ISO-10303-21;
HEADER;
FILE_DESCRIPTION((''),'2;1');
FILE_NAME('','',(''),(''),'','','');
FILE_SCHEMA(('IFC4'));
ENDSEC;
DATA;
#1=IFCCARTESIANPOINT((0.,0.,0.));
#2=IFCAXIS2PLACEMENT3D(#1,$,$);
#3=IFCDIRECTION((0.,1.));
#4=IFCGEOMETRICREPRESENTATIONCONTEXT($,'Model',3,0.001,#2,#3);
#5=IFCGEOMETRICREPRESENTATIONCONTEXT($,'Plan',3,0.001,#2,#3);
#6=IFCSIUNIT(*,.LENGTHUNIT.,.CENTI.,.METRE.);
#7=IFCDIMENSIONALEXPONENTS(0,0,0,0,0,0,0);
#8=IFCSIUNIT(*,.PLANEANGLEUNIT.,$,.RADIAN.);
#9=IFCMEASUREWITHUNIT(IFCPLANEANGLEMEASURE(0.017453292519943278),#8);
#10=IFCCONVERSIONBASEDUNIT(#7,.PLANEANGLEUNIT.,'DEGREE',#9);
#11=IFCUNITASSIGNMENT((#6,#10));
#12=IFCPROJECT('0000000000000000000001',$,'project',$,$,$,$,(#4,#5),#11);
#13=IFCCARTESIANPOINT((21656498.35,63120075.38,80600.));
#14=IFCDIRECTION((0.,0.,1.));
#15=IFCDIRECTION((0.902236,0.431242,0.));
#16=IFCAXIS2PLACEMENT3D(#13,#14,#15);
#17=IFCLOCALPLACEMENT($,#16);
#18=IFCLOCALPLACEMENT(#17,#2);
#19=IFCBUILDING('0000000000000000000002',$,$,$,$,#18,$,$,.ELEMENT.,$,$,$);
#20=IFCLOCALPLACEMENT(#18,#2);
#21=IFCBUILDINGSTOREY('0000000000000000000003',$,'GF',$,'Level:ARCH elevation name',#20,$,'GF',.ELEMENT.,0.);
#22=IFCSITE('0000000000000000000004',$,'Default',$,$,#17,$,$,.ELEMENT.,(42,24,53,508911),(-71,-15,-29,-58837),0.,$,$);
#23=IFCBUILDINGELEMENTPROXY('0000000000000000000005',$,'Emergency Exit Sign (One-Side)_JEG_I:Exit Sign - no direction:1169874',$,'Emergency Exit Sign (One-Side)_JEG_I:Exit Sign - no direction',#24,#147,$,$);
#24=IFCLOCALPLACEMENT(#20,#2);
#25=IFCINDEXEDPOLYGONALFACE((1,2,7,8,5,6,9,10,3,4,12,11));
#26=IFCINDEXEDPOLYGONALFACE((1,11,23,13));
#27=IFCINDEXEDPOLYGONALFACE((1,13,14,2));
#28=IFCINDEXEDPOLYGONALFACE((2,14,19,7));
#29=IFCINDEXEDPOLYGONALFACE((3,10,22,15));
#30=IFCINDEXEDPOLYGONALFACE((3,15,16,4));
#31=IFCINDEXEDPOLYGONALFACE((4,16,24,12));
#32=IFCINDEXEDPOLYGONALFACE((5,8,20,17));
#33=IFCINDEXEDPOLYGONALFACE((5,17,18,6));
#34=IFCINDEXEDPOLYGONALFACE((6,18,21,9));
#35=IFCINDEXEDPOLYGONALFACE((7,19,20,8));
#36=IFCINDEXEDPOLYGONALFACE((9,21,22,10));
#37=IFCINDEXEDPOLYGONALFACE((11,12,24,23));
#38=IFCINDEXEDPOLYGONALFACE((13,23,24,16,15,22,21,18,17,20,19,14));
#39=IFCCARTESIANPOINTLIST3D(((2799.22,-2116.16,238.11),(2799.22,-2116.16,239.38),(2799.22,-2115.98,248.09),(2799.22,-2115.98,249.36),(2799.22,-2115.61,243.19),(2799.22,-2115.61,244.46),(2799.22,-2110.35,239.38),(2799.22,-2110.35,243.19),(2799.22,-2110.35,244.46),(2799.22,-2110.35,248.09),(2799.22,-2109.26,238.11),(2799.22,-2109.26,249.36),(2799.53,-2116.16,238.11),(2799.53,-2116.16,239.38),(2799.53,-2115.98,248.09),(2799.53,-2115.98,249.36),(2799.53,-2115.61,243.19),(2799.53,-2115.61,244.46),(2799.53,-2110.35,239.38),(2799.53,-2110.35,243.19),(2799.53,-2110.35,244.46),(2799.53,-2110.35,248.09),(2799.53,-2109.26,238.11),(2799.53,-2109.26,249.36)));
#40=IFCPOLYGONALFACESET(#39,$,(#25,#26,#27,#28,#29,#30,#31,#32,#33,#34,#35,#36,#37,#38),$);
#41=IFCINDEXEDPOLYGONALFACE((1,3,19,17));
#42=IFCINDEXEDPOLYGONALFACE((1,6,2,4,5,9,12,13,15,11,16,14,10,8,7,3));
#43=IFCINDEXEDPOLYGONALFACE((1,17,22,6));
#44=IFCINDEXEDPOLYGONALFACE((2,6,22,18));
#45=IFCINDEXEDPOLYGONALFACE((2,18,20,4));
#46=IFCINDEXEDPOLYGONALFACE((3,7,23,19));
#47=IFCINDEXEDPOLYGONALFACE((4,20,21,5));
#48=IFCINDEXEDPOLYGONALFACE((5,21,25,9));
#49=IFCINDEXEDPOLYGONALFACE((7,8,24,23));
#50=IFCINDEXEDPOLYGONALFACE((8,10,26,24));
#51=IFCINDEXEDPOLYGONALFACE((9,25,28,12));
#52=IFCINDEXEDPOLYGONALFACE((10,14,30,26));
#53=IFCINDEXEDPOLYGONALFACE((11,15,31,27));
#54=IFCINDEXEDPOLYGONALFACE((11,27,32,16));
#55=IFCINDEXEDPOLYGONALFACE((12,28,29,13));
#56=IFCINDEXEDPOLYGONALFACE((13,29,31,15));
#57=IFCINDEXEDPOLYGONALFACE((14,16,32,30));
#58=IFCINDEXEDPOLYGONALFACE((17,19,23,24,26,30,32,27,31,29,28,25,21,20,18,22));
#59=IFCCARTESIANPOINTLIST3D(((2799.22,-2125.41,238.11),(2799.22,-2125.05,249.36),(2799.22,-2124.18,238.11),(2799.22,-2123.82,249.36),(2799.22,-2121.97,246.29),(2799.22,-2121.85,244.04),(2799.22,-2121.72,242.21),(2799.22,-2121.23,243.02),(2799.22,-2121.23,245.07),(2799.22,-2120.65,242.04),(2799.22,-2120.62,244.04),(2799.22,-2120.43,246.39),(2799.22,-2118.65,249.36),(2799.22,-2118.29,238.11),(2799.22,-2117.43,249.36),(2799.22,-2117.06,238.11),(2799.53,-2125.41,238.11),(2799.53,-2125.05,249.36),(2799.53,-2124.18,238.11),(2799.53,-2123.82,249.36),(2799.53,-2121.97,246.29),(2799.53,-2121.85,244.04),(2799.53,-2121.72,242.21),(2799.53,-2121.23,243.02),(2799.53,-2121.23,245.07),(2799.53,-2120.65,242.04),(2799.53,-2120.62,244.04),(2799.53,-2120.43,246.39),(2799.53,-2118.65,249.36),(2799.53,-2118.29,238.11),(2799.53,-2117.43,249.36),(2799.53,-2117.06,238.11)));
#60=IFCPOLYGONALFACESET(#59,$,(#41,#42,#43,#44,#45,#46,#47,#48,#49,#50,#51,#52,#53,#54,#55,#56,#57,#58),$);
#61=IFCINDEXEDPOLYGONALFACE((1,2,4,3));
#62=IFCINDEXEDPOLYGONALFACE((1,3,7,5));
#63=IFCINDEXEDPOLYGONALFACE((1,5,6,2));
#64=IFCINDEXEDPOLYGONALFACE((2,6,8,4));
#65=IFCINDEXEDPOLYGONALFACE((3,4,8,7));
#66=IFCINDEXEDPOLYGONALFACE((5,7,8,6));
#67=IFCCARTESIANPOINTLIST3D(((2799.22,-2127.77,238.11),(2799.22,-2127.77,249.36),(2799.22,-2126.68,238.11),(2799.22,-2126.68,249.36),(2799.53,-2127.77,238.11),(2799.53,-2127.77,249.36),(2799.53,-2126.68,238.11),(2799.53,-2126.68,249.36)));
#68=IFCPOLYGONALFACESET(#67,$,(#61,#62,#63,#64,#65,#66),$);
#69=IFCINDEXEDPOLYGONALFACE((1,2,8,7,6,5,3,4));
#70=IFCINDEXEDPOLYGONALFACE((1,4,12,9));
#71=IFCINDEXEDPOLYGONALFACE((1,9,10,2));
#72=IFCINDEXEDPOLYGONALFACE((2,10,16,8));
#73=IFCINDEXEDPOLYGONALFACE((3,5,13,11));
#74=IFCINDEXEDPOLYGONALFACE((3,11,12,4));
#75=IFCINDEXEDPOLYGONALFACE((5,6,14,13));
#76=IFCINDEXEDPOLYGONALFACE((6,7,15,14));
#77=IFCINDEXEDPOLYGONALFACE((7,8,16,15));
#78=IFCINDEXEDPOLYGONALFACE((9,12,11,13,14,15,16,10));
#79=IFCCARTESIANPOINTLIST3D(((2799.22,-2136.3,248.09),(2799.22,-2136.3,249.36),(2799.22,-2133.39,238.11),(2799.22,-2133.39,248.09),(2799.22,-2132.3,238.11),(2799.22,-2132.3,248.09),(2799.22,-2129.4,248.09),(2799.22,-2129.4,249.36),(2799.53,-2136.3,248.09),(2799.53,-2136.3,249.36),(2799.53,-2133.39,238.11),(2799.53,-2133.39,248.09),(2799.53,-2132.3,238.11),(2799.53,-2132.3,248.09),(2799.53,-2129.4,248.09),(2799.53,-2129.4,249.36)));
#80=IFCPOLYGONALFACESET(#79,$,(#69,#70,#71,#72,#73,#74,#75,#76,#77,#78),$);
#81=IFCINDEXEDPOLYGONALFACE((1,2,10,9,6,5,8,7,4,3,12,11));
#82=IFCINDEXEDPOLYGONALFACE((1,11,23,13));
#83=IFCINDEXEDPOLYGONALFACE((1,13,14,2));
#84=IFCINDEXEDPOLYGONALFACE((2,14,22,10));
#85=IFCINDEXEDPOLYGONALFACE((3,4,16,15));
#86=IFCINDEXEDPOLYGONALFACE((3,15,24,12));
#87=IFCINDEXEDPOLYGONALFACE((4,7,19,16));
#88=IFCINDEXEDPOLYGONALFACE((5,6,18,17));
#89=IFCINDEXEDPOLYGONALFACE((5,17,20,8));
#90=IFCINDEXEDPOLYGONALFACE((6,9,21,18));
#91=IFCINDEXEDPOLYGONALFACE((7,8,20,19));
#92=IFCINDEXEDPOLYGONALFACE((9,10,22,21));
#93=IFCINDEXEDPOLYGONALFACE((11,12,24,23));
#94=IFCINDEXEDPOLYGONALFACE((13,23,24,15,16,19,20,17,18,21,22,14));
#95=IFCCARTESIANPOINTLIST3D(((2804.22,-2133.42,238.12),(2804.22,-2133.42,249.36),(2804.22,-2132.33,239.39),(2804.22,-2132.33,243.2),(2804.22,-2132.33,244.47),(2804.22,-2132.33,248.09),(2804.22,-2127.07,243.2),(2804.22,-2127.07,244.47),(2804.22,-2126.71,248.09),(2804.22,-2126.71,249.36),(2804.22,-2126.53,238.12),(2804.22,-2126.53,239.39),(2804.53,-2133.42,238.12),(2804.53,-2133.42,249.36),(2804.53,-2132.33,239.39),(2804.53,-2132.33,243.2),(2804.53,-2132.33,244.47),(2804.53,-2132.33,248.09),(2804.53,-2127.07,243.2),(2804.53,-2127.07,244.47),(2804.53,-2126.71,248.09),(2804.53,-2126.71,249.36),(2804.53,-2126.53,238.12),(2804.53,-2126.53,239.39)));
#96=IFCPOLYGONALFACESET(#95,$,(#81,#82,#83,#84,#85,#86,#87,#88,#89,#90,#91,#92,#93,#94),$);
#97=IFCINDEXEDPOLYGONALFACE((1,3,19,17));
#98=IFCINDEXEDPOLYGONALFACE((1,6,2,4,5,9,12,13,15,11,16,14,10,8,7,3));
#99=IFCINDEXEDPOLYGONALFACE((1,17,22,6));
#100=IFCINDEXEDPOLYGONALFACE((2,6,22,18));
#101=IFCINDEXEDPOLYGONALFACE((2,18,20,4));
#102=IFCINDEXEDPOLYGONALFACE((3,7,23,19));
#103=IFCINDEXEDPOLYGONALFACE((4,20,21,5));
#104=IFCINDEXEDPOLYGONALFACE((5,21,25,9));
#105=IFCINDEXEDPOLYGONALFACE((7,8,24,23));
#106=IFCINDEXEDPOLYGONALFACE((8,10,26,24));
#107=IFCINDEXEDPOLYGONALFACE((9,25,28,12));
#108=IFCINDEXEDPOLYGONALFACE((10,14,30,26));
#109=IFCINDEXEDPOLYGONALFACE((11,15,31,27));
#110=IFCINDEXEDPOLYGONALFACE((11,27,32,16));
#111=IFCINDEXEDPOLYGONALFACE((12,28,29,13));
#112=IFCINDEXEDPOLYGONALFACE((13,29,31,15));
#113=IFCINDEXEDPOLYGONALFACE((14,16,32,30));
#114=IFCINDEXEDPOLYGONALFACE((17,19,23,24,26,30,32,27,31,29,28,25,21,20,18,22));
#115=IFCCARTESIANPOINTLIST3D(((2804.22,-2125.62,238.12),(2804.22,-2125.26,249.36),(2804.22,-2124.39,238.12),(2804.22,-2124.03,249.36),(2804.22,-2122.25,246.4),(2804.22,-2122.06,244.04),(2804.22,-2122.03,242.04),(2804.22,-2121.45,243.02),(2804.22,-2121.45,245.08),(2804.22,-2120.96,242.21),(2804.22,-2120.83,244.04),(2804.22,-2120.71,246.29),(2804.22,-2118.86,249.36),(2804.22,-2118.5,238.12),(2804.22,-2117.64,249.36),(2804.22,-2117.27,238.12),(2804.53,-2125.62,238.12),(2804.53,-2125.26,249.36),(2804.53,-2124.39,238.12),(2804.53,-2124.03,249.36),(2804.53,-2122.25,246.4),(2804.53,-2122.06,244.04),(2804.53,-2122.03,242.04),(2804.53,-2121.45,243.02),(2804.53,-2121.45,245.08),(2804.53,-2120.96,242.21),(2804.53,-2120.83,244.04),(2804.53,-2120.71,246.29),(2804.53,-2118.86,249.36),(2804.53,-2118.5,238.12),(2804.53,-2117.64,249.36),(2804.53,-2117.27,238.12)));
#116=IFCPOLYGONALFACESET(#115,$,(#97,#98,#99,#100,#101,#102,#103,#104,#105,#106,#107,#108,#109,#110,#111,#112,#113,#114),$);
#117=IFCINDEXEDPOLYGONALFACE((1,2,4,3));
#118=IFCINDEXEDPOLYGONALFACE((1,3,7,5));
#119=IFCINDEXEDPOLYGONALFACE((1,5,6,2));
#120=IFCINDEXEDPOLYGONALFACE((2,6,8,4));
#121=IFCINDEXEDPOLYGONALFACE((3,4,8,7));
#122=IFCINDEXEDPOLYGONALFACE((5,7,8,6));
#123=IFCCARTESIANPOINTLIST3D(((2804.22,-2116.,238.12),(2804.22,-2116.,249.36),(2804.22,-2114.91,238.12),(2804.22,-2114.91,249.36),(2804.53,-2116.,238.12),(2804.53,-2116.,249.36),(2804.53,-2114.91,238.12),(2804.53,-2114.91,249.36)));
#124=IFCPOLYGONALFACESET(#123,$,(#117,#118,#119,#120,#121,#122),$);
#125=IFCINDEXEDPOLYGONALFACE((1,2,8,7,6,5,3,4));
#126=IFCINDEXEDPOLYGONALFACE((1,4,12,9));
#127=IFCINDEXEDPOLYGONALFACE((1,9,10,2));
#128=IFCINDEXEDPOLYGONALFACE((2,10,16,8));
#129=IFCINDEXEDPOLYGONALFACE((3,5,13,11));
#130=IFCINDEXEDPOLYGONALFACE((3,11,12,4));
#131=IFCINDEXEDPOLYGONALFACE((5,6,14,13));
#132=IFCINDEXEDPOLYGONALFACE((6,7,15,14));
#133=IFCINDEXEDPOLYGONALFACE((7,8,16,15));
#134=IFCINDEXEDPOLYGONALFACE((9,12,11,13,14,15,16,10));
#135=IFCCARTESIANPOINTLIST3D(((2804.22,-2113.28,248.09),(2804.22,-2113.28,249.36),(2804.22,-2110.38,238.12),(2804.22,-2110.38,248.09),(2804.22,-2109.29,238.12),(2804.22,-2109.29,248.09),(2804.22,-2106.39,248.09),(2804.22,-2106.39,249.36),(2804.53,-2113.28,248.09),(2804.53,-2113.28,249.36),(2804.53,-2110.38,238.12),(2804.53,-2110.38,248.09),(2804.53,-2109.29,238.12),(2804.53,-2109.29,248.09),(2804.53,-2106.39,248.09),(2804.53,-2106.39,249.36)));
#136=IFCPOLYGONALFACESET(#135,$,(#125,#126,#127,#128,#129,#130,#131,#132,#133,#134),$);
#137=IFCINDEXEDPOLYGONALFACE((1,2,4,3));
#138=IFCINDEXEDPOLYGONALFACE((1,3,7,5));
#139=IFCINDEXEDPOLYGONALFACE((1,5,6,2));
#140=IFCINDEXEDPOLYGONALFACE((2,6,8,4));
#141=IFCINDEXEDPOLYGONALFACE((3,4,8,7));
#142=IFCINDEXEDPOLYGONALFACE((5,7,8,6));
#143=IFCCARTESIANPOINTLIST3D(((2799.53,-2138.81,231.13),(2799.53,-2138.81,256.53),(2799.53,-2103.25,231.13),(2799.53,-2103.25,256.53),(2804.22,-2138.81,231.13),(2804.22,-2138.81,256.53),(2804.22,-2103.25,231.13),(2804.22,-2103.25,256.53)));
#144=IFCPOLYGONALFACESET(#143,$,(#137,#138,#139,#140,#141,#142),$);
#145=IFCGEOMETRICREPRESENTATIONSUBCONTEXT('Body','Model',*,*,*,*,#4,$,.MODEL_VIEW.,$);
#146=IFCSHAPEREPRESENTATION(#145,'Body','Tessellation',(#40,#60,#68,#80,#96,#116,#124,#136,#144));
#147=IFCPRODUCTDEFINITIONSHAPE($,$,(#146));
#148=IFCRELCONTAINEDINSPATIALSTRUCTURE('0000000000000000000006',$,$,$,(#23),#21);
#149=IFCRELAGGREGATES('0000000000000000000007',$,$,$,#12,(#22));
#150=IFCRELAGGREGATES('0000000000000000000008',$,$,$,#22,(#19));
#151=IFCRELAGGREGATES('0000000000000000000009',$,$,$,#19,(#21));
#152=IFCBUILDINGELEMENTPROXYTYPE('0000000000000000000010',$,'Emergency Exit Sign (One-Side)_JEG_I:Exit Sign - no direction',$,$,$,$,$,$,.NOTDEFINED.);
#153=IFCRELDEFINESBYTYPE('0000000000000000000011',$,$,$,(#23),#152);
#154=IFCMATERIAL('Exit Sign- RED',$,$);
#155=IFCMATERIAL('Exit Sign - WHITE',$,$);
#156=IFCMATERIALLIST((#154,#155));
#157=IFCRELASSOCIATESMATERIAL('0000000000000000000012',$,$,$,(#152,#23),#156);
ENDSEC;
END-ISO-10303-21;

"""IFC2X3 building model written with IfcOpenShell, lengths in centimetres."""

from ifc_helpers import new_model, entity, si_unit, converted_unit, direction, frame, frame_2d, origin, origin_2d_with_axis, place, context, subcontext, project, spatial, polyline, rectangle, outline, extrude, source, transform, mapped, material, material_list, type_object, type_shapes, element, save


model = new_model("IFC2X3")

# Units and contexts
model_context = context("Model", 3, precision=0.001, world=origin(), true_north=direction((0.0, 1.0)))
plan_context = context("Plan", 3, precision=0.001, world=origin(), true_north=direction((0.0, 1.0)))
body_context = subcontext(model_context, "Body", "Model", "MODEL_VIEW")
ifc_project = project(units=[si_unit("LENGTHUNIT", "METRE", prefix="CENTI"), converted_unit("PLANEANGLEUNIT", "DEGREE", entity("IfcPlaneAngleMeasure", 0.017453292519943278), si_unit("PLANEANGLEUNIT", "RADIAN"), dimensions=[0, 0, 0, 0, 0, 0, 0])], contexts=[model_context, plan_context])

# Site, building, storey
site_placement = place(None, frame((21656498.35, 63120075.38, 80600.0), z_axis=(0.0, 0.0, 1.0), x_axis=(0.902236, 0.431242, 0.0)))
site = spatial("IfcSite", under=ifc_project, at=site_placement, Name="Default", CompositionType="ELEMENT", RefLatitude=(42, 24, 53, 508911), RefLongitude=(-71, -15, -29, -58837), RefElevation=0.0)
building_placement = place(site_placement, origin())
building = spatial("IfcBuilding", under=site, at=building_placement, CompositionType="ELEMENT")
storey_placement = place(building_placement, origin())
storey = spatial("IfcBuildingStorey", under=building, at=storey_placement, Name="GF", ObjectType="Level:ARCH elevation name", LongName="GF", CompositionType="ELEMENT", Elevation=0.0)

# Building element proxy
ifc_material_1 = material(Name="Exit Sign- RED")
ifc_material_2 = material(Name="Exit Sign - WHITE")
ifc_material_list_1 = material_list([ifc_material_1, ifc_material_2])
building_element_proxy_type_1 = type_object("IfcBuildingElementProxyType", Name="Emergency Exit Sign (One-Side)_JEG_I:Exit Sign - no direction", PredefinedType="NOTDEFINED", material=ifc_material_list_1)
shared_shape_1 = source(origin(), body_context, "Body", "SweptSolid", [
    extrude(outline(polyline([(-5.65, -3.69), (5.59, -3.69), (5.59, 3.02), (4.32, 3.02), (4.32, -2.6), (0.7, -2.6), (0.7, 2.66), (-0.57, 2.66), (-0.57, -2.6), (-4.38, -2.6), (-4.38, 3.21), (-5.65, 3.21), (-5.65, -3.69)])), frame((-8.08, -5.22, 12.64), z_axis=(0.0, 1.0, 0.0), x_axis=(0.0, 0.0, 1.0)), (0.0, 0.0, 1.0), 0.32),
    extrude(outline(polyline([(-7.14, 0.57), (-6.5, -0.49), (-1.93, -0.48), (-0.78, -0.48), (-1.23, -1.32), (-3.47, -5.53), (-2.84, -6.59), (0.41, -0.48), (6.62, -0.48), (5.99, 0.57), (2.4, 0.57), (0.98, 0.58), (1.7, 1.94), (3.32, 5.0), (2.69, 6.05), (-0.22, 0.57), (-7.14, 0.57)])), frame((0.2, -5.22, 12.81), z_axis=(0.0, -1.0, 0.0), x_axis=(0.515099, 0.0, 0.857131)), (0.0, 0.0, -1.0), 0.32),
    extrude(rectangle(XDim=0.32, YDim=1.09, at=frame_2d((0.0, 0.0), x_axis=(1.0, 0.0))), frame((6.19, -5.06, 6.99), z_axis=(0.0, 0.0, 1.0), x_axis=(0.0, 1.0, 0.0)), (0.0, 0.0, 1.0), 11.25),
    extrude(outline(polyline([(-7.8, 0.54), (-7.8, -0.54), (2.18, -0.54), (2.18, -3.45), (3.45, -3.45), (3.45, 3.45), (2.18, 3.45), (2.18, 0.54), (-7.8, 0.54)])), frame((11.82, -5.22, 14.79), z_axis=(0.0, -1.0, 0.0), x_axis=(0.0, 0.0, 1.0)), (0.0, 0.0, -1.0), 0.32),
    extrude(outline(polyline([(-3.69, -5.65), (3.21, -5.65), (3.21, -4.38), (-2.6, -4.38), (-2.6, -0.57), (2.66, -0.57), (2.66, 0.7), (-2.6, 0.7), (-2.6, 4.32), (3.02, 4.32), (3.02, 5.59), (-3.69, 5.59), (-3.69, -5.65)])), frame((8.7, -0.22, 12.65), z_axis=(0.0, 1.0, 0.0), x_axis=(-1.0, 0.0, 0.0)), (0.0, 0.0, 1.0), 0.32),
    extrude(outline(polyline([(-4.16, -5.82), (-2.93, -5.82), (-0.58, -1.9), (0.01, -0.92), (0.5, -1.73), (2.96, -5.82), (4.18, -5.82), (0.62, 0.1), (3.82, 5.42), (2.59, 5.42), (0.75, 2.35), (0.01, 1.14), (-0.79, 2.46), (-2.57, 5.42), (-3.8, 5.42), (-0.6, 0.1), (-4.16, -5.82)])), frame((0.43, -0.22, 12.82), z_axis=(0.0, 1.0, 0.0), x_axis=(-1.0, 0.0, 0.0)), (0.0, 0.0, 1.0), 0.32),
    extrude(rectangle(XDim=0.32, YDim=1.09, at=origin_2d_with_axis()), frame((-5.57, -0.06, 6.99), z_axis=(0.0, 0.0, 1.0), x_axis=(0.0, -1.0, 0.0)), (0.0, 0.0, 1.0), 11.25),
    extrude(outline(polyline([(-0.54, -7.8), (0.54, -7.8), (0.54, 2.18), (3.45, 2.18), (3.45, 3.45), (-3.45, 3.45), (-3.45, 2.18), (-0.54, 2.18), (-0.54, -7.8)])), frame((-11.2, -0.22, 14.79), z_axis=(0.0, 1.0, 0.0), x_axis=(-1.0, 0.0, 0.0)), (0.0, 0.0, 1.0), 0.32),
    extrude(rectangle(XDim=4.68, YDim=35.56, at=origin_2d_with_axis()), frame((0.0, -2.56, 0.01), z_axis=(0.0, 0.0, 1.0), x_axis=(0.0, 1.0, 0.0)), (0.0, 0.0, 1.0), 25.4),
])
type_shapes(building_element_proxy_type_1, [shared_shape_1])
for number, where, z_axis, x_axis, name in (
    (1, (2804.44, -2121.03, 231.12), (0.0, 0.0, 1.0), (0.0, -1.0, 0.0), "Emergency Exit Sign (One-Side)_JEG_I:Exit Sign - no direction:1169874"),
):
    element("IfcBuildingElementProxy", number, at=place(storey_placement, frame(where, z_axis=z_axis, x_axis=x_axis)), inside=storey, type_object=building_element_proxy_type_1, material=ifc_material_list_1, Name=name, ObjectType="Emergency Exit Sign (One-Side)_JEG_I:Exit Sign - no direction", context=body_context, shape_type="MappedRepresentation", body=[
        mapped(shared_shape_1, transform((0.0, 0.0, 0.0), scale=1.0)),
    ])

save(model, "model.ifc")
